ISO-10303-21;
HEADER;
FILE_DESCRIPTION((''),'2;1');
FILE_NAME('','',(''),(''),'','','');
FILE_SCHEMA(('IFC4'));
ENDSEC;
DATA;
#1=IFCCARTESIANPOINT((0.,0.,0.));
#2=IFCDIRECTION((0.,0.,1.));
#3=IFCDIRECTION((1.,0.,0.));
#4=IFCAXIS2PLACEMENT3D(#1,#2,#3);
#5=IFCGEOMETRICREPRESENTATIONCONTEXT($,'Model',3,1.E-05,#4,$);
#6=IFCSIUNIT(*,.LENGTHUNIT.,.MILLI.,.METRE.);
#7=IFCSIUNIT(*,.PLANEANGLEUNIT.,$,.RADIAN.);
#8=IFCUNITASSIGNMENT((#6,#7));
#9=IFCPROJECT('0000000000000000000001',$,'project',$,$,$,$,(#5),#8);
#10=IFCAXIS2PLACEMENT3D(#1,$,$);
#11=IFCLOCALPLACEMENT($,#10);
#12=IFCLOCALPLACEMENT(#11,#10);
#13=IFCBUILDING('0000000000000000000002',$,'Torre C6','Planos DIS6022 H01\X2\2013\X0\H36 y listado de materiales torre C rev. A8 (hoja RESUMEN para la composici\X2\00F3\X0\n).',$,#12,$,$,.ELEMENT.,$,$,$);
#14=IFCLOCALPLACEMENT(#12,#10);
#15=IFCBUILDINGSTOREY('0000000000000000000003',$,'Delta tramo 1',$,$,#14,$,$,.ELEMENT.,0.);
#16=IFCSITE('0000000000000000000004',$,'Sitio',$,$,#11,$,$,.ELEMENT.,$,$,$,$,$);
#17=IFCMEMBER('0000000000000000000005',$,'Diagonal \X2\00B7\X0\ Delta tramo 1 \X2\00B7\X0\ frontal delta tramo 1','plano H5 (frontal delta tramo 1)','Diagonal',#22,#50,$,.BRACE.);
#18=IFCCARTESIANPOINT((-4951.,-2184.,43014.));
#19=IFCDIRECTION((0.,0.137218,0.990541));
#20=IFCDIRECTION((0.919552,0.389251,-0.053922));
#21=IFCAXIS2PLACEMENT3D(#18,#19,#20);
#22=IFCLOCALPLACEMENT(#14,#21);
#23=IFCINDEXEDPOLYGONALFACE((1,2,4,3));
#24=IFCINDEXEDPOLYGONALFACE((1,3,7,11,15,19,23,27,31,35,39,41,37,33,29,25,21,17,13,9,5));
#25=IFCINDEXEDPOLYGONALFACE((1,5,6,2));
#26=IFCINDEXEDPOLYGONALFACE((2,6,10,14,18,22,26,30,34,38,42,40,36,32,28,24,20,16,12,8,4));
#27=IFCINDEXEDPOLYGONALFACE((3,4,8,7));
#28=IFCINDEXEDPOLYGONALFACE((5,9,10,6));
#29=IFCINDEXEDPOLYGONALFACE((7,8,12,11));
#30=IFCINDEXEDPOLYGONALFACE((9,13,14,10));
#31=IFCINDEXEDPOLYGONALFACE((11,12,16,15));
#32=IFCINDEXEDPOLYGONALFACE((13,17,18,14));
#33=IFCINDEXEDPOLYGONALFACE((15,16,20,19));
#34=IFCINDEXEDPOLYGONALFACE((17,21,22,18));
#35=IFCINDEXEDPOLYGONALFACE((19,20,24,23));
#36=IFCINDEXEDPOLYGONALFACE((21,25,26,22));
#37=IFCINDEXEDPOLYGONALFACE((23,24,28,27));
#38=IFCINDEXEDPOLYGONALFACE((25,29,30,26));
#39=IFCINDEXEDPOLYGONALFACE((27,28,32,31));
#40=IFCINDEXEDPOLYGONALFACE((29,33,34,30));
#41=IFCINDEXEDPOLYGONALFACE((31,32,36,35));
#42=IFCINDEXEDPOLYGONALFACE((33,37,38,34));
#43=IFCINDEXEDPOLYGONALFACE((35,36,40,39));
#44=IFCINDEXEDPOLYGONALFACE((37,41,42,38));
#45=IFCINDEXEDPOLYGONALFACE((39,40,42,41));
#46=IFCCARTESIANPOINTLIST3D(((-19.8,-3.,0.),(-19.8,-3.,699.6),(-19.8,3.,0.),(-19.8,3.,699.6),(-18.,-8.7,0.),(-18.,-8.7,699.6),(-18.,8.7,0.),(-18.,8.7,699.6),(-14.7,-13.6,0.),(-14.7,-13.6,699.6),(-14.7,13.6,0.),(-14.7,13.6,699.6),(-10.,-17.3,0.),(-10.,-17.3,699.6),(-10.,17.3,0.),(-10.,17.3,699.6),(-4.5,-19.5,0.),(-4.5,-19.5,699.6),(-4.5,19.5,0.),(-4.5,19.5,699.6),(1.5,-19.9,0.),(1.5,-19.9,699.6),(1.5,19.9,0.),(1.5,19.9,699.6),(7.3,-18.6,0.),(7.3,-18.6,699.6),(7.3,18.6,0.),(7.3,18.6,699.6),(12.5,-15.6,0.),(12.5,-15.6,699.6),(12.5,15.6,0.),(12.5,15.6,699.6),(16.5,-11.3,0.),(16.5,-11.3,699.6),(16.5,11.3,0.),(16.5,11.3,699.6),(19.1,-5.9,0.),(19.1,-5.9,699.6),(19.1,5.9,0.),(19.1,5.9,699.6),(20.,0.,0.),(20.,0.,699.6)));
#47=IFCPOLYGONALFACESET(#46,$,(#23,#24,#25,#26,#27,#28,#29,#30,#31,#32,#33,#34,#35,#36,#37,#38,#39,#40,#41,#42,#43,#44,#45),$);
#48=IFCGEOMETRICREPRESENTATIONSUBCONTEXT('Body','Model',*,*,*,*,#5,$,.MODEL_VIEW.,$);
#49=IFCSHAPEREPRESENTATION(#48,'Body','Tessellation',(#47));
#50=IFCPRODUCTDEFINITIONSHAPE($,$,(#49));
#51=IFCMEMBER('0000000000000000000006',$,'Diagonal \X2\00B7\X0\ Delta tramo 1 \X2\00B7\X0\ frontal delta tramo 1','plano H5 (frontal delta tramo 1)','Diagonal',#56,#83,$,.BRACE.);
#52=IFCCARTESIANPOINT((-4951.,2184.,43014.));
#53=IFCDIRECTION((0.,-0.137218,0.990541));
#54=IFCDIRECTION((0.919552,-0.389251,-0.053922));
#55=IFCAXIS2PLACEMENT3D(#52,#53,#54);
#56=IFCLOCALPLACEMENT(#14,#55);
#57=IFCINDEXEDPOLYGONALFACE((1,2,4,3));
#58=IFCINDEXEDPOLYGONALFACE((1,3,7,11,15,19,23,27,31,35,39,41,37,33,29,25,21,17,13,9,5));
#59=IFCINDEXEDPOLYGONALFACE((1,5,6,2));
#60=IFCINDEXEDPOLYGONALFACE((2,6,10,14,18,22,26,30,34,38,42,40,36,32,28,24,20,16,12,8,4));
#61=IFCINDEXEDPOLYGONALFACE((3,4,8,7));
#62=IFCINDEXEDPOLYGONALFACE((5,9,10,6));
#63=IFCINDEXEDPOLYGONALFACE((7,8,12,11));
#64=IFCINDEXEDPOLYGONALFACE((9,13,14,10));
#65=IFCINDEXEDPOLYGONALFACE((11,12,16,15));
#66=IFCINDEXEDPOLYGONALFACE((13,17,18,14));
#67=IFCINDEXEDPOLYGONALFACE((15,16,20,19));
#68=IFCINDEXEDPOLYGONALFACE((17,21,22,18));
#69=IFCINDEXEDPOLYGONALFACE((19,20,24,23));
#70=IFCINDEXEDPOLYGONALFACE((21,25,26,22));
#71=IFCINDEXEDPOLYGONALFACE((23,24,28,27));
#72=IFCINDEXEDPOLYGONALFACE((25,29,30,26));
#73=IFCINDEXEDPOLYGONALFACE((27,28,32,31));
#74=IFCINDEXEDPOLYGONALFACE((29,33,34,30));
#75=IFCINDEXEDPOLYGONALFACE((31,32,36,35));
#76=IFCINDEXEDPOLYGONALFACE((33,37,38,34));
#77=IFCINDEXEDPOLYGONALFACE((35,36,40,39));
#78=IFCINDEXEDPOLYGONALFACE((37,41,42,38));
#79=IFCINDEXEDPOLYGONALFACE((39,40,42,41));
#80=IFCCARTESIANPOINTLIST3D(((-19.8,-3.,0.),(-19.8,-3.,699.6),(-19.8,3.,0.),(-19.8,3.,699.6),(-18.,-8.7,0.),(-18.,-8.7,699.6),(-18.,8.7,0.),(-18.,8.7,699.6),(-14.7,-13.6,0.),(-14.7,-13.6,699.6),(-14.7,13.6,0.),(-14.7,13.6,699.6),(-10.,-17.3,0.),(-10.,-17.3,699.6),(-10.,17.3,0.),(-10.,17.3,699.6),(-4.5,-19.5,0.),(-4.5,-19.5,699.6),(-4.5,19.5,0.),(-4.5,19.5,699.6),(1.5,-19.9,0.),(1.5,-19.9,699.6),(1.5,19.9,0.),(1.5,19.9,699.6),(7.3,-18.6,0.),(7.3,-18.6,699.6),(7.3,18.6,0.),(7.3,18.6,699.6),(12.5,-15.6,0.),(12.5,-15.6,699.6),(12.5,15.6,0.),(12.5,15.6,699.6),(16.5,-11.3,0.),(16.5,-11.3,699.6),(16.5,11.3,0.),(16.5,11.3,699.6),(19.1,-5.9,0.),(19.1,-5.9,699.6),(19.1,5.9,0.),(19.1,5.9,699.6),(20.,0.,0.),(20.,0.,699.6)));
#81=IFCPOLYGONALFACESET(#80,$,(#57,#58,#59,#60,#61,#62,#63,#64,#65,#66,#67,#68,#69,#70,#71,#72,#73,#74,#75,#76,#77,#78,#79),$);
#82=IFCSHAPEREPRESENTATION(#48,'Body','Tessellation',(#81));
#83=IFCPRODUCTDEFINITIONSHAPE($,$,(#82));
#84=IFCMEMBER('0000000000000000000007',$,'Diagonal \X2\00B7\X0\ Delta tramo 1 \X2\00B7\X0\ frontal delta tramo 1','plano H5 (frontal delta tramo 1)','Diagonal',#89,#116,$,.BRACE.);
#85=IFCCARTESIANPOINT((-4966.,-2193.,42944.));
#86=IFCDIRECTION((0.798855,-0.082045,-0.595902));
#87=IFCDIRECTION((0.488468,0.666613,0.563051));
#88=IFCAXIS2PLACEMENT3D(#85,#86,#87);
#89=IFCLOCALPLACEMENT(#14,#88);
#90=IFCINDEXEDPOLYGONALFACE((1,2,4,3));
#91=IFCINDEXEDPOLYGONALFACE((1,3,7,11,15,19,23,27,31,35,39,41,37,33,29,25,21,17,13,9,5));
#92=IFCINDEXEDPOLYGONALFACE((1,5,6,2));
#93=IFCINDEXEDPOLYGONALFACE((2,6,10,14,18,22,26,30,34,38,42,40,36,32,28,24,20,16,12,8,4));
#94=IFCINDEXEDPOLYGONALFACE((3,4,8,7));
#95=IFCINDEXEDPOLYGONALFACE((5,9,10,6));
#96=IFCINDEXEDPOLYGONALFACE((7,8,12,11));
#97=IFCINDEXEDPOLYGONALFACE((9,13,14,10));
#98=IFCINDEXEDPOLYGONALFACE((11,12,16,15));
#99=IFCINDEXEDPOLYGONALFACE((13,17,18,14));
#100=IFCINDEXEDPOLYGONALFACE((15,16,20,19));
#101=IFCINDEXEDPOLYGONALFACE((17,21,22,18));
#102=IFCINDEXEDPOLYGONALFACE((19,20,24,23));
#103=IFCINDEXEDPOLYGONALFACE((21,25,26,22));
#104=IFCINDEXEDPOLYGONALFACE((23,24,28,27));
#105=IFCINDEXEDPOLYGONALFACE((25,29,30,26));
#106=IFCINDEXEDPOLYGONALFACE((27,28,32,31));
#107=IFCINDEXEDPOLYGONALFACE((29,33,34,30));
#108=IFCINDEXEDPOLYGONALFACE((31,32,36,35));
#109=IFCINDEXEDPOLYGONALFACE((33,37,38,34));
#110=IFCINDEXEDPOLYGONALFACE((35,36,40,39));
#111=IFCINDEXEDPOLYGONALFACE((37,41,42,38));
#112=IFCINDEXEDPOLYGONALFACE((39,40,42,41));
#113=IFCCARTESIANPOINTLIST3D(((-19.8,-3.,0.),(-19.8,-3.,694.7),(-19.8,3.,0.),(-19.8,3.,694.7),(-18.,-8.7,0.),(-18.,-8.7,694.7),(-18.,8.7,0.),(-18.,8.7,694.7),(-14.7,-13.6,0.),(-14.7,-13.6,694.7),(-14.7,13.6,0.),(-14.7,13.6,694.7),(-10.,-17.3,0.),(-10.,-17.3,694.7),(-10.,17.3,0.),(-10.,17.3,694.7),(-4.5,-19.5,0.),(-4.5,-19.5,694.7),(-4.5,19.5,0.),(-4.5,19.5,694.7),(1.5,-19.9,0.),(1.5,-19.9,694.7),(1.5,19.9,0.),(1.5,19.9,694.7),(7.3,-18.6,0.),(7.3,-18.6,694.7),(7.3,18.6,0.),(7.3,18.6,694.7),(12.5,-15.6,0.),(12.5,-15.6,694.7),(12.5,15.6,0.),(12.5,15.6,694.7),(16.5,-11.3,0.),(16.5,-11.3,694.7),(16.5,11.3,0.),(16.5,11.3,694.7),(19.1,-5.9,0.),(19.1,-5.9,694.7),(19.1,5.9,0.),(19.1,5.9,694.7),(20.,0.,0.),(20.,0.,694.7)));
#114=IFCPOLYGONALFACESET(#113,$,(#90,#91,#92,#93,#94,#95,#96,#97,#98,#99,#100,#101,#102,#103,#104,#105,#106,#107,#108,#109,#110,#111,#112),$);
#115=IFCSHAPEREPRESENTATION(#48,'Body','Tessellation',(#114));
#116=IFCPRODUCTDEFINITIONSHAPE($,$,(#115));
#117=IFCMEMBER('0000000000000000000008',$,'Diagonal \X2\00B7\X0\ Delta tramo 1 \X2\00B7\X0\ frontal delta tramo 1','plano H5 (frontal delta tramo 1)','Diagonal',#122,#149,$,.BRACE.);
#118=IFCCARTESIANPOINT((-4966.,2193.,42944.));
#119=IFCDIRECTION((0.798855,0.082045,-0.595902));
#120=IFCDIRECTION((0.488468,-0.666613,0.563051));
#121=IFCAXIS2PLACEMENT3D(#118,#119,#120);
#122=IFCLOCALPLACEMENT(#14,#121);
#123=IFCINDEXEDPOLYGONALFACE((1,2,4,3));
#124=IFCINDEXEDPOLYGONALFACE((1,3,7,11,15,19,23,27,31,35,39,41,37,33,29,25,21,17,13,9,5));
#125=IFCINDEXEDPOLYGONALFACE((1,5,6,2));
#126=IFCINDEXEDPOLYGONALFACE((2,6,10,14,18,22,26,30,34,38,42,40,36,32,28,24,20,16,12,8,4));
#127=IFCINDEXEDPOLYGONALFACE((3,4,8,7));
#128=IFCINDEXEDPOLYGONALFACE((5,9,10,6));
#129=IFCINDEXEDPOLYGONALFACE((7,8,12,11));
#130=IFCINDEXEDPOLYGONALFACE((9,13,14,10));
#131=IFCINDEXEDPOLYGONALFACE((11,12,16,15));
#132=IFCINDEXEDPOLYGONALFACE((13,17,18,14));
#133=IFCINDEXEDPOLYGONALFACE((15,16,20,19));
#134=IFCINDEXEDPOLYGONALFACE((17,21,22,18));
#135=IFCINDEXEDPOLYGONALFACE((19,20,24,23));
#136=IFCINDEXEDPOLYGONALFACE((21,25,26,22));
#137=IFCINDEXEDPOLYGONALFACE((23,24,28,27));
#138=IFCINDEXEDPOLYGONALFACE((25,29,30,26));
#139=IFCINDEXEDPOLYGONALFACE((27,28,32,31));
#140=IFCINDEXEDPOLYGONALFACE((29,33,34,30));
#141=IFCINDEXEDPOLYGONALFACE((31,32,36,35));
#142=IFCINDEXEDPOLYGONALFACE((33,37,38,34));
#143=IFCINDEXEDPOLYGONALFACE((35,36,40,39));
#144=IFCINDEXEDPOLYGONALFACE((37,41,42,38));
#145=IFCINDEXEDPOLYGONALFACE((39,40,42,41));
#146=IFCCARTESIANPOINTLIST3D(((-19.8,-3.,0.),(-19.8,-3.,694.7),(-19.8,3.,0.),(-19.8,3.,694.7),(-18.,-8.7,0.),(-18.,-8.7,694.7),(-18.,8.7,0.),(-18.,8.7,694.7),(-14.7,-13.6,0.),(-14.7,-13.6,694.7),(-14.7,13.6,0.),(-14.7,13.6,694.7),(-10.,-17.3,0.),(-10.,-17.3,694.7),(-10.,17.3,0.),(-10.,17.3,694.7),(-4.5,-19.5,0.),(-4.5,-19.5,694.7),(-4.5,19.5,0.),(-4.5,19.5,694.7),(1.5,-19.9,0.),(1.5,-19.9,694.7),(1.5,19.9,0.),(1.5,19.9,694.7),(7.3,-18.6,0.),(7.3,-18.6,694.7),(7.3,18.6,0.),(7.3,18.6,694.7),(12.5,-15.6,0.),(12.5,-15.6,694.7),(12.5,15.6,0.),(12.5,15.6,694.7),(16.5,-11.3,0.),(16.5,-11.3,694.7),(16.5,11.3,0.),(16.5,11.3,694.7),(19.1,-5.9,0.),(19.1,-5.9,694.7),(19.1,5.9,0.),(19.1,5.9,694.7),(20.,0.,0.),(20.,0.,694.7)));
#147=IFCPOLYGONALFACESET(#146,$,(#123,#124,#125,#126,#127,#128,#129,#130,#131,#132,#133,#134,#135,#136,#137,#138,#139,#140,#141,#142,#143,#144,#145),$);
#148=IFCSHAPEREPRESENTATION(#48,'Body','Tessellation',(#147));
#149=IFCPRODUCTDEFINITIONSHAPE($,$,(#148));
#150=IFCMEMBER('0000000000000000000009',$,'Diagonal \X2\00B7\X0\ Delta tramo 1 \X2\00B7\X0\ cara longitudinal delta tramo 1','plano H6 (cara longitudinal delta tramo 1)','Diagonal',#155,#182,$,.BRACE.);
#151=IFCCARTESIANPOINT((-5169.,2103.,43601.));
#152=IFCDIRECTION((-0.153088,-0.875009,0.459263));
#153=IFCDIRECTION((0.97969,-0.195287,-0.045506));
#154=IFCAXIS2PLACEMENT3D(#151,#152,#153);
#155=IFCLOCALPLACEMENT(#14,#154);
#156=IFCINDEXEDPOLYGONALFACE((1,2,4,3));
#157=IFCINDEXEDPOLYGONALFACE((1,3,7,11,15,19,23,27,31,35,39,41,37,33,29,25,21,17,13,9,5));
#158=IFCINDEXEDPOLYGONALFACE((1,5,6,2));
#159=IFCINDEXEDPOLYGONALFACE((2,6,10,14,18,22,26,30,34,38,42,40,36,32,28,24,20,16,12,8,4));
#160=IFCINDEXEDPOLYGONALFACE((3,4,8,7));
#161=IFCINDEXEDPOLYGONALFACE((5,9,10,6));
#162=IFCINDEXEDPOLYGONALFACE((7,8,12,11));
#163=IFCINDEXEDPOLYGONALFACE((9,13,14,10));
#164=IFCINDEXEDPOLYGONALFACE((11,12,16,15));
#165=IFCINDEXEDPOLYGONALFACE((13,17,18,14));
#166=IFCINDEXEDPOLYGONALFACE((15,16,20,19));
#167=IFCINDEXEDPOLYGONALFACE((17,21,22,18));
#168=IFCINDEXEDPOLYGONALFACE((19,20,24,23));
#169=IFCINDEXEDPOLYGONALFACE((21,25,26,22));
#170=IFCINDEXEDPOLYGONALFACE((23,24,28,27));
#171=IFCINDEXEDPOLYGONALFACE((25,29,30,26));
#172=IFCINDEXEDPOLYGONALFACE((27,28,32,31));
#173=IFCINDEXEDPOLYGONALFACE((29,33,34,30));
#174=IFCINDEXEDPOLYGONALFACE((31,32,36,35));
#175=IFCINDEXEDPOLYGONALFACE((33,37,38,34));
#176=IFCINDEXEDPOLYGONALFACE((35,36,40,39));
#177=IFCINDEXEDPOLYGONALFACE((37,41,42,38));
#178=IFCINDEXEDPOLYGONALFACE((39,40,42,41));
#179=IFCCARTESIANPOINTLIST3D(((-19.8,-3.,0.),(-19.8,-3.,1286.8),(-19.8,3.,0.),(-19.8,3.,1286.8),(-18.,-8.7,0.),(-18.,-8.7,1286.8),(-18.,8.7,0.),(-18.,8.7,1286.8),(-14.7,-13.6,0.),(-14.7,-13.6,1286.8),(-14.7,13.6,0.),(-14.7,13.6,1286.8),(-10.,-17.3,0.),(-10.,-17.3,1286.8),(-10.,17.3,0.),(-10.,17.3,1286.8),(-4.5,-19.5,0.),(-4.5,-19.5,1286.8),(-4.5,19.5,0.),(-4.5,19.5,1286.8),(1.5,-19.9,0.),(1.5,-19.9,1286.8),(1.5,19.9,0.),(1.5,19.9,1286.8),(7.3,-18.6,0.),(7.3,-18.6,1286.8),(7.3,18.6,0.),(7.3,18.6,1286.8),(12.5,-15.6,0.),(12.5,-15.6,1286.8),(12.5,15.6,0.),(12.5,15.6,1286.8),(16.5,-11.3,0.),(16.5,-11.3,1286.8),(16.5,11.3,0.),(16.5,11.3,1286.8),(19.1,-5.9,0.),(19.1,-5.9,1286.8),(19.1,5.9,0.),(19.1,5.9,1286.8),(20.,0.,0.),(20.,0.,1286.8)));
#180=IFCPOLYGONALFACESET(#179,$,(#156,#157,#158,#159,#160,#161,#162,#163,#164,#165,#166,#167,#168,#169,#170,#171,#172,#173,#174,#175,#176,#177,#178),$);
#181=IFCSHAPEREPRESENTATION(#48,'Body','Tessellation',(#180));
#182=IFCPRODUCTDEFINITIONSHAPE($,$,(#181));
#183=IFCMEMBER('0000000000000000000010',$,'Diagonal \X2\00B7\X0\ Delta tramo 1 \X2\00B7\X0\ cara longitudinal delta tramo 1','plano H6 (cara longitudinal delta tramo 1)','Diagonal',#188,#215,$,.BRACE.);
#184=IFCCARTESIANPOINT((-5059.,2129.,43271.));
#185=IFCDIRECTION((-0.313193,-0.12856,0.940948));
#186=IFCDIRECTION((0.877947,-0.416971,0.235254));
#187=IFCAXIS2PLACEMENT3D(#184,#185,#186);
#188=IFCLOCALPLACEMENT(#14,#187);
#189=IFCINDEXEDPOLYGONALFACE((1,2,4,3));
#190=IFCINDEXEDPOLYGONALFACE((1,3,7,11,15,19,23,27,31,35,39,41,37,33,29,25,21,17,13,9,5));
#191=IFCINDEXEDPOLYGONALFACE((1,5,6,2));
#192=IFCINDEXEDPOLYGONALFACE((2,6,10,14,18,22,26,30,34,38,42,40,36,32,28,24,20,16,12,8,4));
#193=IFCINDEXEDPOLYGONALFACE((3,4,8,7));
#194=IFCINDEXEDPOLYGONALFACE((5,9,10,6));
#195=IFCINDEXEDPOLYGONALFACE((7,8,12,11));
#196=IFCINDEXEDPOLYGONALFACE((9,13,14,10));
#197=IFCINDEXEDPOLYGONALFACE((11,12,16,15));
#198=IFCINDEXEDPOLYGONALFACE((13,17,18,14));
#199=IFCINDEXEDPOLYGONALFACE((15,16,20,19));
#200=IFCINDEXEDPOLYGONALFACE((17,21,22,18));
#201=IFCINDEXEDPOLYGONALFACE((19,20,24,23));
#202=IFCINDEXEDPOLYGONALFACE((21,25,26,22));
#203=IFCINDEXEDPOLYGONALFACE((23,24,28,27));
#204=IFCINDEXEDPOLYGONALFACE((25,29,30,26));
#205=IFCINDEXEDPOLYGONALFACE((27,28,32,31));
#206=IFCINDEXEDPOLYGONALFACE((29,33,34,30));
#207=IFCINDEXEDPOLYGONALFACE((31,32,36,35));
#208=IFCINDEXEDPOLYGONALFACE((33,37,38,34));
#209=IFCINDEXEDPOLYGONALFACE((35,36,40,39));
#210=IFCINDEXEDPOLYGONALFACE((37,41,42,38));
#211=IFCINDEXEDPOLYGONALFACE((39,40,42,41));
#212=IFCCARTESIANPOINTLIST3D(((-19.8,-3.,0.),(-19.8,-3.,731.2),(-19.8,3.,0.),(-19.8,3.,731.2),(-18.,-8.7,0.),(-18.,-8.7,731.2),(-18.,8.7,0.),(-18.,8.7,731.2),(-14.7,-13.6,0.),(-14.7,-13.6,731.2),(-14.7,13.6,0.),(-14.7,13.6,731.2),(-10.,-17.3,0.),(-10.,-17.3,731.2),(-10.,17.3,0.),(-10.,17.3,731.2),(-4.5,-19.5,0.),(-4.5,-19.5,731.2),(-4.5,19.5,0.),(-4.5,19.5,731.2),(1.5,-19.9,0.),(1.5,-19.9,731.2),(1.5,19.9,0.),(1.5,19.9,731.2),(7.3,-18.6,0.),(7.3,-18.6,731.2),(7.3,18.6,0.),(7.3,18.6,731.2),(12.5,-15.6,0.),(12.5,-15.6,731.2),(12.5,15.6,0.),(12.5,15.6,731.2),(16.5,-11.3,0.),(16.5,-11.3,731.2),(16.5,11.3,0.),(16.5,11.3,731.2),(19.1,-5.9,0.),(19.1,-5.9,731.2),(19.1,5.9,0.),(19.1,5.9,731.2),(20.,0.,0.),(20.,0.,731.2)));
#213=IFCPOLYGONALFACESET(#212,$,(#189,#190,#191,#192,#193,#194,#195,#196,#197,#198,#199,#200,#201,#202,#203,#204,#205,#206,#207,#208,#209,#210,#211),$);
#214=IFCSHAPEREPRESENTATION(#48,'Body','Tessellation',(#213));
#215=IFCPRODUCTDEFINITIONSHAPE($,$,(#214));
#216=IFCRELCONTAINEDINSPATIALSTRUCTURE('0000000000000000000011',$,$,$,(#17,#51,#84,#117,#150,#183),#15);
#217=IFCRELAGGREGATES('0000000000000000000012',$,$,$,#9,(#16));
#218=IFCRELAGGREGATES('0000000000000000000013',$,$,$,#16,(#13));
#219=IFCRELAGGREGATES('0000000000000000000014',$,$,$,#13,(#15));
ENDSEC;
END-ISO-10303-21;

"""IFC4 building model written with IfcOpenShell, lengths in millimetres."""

from ifc_helpers import new_model, si_unit, frame, origin, origin_with_axes, place, context, subcontext, project, spatial, circle, extrude, element, save


model = new_model("IFC4")

# Units and contexts
model_context = context("Model", 3, precision=1e-05, world=origin_with_axes())
body_context = subcontext(model_context, "Body", "Model", "MODEL_VIEW")
ifc_project = project(units=[si_unit("LENGTHUNIT", "METRE", prefix="MILLI"), si_unit("PLANEANGLEUNIT", "RADIAN")], contexts=[model_context])

# Site, building, storey
site_placement = place(None, origin())
site = spatial("IfcSite", under=ifc_project, at=site_placement, Name="Sitio", CompositionType="ELEMENT")
building_placement = place(site_placement, origin())
building = spatial("IfcBuilding", under=site, at=building_placement, Name="Torre C6", Description="Planos DIS6022 H01–H36 y listado de materiales torre C rev. A8 (hoja RESUMEN para la composición).", CompositionType="ELEMENT")
storey_placement = place(building_placement, origin())
storey = spatial("IfcBuildingStorey", under=building, at=storey_placement, Name="Delta tramo 1", CompositionType="ELEMENT", Elevation=0.0)

# Members
for number, where, z_axis, x_axis, name in (
    (1, (-4951.0, -2184.0, 43014.0), (0.0, 0.137218, 0.990541), (0.919552, 0.389251, -0.053922), "Diagonal · Delta tramo 1 · frontal delta tramo 1"),
    (2, (-4951.0, 2184.0, 43014.0), (0.0, -0.137218, 0.990541), (0.919552, -0.389251, -0.053922), "Diagonal · Delta tramo 1 · frontal delta tramo 1"),
):
    element("IfcMember", number, at=place(storey_placement, frame(where, z_axis=z_axis, x_axis=x_axis)), inside=storey, Name=name, Description="plano H5 (frontal delta tramo 1)", ObjectType="Diagonal", PredefinedType="BRACE", context=body_context, shape_type="SweptSolid", body=[
        extrude(circle(Radius=20.0), None, (0.0, 0.0, 1.0), 699.6),
    ])
for number, where, z_axis, x_axis, name in (
    (3, (-4966.0, -2193.0, 42944.0), (0.798855, -0.082045, -0.595902), (0.488468, 0.666613, 0.563051), "Diagonal · Delta tramo 1 · frontal delta tramo 1"),
    (4, (-4966.0, 2193.0, 42944.0), (0.798855, 0.082045, -0.595902), (0.488468, -0.666613, 0.563051), "Diagonal · Delta tramo 1 · frontal delta tramo 1"),
):
    element("IfcMember", number, at=place(storey_placement, frame(where, z_axis=z_axis, x_axis=x_axis)), inside=storey, Name=name, Description="plano H5 (frontal delta tramo 1)", ObjectType="Diagonal", PredefinedType="BRACE", context=body_context, shape_type="SweptSolid", body=[
        extrude(circle(Radius=20.0), None, (0.0, 0.0, 1.0), 694.7),
    ])
member_1_placement = place(storey_placement, frame((-5169.0, 2103.0, 43601.0), z_axis=(-0.153088, -0.875009, 0.459263), x_axis=(0.97969, -0.195287, -0.045506)))
element("IfcMember", 5, at=member_1_placement, inside=storey, Name="Diagonal · Delta tramo 1 · cara longitudinal delta tramo 1", Description="plano H6 (cara longitudinal delta tramo 1)", ObjectType="Diagonal", PredefinedType="BRACE", context=body_context, shape_type="SweptSolid", body=[
    extrude(circle(Radius=20.0), None, (0.0, 0.0, 1.0), 1286.8),
])
member_2_placement = place(storey_placement, frame((-5059.0, 2129.0, 43271.0), z_axis=(-0.313193, -0.12856, 0.940948), x_axis=(0.877947, -0.416971, 0.235254)))
element("IfcMember", 6, at=member_2_placement, inside=storey, Name="Diagonal · Delta tramo 1 · cara longitudinal delta tramo 1", Description="plano H6 (cara longitudinal delta tramo 1)", ObjectType="Diagonal", PredefinedType="BRACE", context=body_context, shape_type="SweptSolid", body=[
    extrude(circle(Radius=20.0), None, (0.0, 0.0, 1.0), 731.2),
])

save(model, "model.ifc")
